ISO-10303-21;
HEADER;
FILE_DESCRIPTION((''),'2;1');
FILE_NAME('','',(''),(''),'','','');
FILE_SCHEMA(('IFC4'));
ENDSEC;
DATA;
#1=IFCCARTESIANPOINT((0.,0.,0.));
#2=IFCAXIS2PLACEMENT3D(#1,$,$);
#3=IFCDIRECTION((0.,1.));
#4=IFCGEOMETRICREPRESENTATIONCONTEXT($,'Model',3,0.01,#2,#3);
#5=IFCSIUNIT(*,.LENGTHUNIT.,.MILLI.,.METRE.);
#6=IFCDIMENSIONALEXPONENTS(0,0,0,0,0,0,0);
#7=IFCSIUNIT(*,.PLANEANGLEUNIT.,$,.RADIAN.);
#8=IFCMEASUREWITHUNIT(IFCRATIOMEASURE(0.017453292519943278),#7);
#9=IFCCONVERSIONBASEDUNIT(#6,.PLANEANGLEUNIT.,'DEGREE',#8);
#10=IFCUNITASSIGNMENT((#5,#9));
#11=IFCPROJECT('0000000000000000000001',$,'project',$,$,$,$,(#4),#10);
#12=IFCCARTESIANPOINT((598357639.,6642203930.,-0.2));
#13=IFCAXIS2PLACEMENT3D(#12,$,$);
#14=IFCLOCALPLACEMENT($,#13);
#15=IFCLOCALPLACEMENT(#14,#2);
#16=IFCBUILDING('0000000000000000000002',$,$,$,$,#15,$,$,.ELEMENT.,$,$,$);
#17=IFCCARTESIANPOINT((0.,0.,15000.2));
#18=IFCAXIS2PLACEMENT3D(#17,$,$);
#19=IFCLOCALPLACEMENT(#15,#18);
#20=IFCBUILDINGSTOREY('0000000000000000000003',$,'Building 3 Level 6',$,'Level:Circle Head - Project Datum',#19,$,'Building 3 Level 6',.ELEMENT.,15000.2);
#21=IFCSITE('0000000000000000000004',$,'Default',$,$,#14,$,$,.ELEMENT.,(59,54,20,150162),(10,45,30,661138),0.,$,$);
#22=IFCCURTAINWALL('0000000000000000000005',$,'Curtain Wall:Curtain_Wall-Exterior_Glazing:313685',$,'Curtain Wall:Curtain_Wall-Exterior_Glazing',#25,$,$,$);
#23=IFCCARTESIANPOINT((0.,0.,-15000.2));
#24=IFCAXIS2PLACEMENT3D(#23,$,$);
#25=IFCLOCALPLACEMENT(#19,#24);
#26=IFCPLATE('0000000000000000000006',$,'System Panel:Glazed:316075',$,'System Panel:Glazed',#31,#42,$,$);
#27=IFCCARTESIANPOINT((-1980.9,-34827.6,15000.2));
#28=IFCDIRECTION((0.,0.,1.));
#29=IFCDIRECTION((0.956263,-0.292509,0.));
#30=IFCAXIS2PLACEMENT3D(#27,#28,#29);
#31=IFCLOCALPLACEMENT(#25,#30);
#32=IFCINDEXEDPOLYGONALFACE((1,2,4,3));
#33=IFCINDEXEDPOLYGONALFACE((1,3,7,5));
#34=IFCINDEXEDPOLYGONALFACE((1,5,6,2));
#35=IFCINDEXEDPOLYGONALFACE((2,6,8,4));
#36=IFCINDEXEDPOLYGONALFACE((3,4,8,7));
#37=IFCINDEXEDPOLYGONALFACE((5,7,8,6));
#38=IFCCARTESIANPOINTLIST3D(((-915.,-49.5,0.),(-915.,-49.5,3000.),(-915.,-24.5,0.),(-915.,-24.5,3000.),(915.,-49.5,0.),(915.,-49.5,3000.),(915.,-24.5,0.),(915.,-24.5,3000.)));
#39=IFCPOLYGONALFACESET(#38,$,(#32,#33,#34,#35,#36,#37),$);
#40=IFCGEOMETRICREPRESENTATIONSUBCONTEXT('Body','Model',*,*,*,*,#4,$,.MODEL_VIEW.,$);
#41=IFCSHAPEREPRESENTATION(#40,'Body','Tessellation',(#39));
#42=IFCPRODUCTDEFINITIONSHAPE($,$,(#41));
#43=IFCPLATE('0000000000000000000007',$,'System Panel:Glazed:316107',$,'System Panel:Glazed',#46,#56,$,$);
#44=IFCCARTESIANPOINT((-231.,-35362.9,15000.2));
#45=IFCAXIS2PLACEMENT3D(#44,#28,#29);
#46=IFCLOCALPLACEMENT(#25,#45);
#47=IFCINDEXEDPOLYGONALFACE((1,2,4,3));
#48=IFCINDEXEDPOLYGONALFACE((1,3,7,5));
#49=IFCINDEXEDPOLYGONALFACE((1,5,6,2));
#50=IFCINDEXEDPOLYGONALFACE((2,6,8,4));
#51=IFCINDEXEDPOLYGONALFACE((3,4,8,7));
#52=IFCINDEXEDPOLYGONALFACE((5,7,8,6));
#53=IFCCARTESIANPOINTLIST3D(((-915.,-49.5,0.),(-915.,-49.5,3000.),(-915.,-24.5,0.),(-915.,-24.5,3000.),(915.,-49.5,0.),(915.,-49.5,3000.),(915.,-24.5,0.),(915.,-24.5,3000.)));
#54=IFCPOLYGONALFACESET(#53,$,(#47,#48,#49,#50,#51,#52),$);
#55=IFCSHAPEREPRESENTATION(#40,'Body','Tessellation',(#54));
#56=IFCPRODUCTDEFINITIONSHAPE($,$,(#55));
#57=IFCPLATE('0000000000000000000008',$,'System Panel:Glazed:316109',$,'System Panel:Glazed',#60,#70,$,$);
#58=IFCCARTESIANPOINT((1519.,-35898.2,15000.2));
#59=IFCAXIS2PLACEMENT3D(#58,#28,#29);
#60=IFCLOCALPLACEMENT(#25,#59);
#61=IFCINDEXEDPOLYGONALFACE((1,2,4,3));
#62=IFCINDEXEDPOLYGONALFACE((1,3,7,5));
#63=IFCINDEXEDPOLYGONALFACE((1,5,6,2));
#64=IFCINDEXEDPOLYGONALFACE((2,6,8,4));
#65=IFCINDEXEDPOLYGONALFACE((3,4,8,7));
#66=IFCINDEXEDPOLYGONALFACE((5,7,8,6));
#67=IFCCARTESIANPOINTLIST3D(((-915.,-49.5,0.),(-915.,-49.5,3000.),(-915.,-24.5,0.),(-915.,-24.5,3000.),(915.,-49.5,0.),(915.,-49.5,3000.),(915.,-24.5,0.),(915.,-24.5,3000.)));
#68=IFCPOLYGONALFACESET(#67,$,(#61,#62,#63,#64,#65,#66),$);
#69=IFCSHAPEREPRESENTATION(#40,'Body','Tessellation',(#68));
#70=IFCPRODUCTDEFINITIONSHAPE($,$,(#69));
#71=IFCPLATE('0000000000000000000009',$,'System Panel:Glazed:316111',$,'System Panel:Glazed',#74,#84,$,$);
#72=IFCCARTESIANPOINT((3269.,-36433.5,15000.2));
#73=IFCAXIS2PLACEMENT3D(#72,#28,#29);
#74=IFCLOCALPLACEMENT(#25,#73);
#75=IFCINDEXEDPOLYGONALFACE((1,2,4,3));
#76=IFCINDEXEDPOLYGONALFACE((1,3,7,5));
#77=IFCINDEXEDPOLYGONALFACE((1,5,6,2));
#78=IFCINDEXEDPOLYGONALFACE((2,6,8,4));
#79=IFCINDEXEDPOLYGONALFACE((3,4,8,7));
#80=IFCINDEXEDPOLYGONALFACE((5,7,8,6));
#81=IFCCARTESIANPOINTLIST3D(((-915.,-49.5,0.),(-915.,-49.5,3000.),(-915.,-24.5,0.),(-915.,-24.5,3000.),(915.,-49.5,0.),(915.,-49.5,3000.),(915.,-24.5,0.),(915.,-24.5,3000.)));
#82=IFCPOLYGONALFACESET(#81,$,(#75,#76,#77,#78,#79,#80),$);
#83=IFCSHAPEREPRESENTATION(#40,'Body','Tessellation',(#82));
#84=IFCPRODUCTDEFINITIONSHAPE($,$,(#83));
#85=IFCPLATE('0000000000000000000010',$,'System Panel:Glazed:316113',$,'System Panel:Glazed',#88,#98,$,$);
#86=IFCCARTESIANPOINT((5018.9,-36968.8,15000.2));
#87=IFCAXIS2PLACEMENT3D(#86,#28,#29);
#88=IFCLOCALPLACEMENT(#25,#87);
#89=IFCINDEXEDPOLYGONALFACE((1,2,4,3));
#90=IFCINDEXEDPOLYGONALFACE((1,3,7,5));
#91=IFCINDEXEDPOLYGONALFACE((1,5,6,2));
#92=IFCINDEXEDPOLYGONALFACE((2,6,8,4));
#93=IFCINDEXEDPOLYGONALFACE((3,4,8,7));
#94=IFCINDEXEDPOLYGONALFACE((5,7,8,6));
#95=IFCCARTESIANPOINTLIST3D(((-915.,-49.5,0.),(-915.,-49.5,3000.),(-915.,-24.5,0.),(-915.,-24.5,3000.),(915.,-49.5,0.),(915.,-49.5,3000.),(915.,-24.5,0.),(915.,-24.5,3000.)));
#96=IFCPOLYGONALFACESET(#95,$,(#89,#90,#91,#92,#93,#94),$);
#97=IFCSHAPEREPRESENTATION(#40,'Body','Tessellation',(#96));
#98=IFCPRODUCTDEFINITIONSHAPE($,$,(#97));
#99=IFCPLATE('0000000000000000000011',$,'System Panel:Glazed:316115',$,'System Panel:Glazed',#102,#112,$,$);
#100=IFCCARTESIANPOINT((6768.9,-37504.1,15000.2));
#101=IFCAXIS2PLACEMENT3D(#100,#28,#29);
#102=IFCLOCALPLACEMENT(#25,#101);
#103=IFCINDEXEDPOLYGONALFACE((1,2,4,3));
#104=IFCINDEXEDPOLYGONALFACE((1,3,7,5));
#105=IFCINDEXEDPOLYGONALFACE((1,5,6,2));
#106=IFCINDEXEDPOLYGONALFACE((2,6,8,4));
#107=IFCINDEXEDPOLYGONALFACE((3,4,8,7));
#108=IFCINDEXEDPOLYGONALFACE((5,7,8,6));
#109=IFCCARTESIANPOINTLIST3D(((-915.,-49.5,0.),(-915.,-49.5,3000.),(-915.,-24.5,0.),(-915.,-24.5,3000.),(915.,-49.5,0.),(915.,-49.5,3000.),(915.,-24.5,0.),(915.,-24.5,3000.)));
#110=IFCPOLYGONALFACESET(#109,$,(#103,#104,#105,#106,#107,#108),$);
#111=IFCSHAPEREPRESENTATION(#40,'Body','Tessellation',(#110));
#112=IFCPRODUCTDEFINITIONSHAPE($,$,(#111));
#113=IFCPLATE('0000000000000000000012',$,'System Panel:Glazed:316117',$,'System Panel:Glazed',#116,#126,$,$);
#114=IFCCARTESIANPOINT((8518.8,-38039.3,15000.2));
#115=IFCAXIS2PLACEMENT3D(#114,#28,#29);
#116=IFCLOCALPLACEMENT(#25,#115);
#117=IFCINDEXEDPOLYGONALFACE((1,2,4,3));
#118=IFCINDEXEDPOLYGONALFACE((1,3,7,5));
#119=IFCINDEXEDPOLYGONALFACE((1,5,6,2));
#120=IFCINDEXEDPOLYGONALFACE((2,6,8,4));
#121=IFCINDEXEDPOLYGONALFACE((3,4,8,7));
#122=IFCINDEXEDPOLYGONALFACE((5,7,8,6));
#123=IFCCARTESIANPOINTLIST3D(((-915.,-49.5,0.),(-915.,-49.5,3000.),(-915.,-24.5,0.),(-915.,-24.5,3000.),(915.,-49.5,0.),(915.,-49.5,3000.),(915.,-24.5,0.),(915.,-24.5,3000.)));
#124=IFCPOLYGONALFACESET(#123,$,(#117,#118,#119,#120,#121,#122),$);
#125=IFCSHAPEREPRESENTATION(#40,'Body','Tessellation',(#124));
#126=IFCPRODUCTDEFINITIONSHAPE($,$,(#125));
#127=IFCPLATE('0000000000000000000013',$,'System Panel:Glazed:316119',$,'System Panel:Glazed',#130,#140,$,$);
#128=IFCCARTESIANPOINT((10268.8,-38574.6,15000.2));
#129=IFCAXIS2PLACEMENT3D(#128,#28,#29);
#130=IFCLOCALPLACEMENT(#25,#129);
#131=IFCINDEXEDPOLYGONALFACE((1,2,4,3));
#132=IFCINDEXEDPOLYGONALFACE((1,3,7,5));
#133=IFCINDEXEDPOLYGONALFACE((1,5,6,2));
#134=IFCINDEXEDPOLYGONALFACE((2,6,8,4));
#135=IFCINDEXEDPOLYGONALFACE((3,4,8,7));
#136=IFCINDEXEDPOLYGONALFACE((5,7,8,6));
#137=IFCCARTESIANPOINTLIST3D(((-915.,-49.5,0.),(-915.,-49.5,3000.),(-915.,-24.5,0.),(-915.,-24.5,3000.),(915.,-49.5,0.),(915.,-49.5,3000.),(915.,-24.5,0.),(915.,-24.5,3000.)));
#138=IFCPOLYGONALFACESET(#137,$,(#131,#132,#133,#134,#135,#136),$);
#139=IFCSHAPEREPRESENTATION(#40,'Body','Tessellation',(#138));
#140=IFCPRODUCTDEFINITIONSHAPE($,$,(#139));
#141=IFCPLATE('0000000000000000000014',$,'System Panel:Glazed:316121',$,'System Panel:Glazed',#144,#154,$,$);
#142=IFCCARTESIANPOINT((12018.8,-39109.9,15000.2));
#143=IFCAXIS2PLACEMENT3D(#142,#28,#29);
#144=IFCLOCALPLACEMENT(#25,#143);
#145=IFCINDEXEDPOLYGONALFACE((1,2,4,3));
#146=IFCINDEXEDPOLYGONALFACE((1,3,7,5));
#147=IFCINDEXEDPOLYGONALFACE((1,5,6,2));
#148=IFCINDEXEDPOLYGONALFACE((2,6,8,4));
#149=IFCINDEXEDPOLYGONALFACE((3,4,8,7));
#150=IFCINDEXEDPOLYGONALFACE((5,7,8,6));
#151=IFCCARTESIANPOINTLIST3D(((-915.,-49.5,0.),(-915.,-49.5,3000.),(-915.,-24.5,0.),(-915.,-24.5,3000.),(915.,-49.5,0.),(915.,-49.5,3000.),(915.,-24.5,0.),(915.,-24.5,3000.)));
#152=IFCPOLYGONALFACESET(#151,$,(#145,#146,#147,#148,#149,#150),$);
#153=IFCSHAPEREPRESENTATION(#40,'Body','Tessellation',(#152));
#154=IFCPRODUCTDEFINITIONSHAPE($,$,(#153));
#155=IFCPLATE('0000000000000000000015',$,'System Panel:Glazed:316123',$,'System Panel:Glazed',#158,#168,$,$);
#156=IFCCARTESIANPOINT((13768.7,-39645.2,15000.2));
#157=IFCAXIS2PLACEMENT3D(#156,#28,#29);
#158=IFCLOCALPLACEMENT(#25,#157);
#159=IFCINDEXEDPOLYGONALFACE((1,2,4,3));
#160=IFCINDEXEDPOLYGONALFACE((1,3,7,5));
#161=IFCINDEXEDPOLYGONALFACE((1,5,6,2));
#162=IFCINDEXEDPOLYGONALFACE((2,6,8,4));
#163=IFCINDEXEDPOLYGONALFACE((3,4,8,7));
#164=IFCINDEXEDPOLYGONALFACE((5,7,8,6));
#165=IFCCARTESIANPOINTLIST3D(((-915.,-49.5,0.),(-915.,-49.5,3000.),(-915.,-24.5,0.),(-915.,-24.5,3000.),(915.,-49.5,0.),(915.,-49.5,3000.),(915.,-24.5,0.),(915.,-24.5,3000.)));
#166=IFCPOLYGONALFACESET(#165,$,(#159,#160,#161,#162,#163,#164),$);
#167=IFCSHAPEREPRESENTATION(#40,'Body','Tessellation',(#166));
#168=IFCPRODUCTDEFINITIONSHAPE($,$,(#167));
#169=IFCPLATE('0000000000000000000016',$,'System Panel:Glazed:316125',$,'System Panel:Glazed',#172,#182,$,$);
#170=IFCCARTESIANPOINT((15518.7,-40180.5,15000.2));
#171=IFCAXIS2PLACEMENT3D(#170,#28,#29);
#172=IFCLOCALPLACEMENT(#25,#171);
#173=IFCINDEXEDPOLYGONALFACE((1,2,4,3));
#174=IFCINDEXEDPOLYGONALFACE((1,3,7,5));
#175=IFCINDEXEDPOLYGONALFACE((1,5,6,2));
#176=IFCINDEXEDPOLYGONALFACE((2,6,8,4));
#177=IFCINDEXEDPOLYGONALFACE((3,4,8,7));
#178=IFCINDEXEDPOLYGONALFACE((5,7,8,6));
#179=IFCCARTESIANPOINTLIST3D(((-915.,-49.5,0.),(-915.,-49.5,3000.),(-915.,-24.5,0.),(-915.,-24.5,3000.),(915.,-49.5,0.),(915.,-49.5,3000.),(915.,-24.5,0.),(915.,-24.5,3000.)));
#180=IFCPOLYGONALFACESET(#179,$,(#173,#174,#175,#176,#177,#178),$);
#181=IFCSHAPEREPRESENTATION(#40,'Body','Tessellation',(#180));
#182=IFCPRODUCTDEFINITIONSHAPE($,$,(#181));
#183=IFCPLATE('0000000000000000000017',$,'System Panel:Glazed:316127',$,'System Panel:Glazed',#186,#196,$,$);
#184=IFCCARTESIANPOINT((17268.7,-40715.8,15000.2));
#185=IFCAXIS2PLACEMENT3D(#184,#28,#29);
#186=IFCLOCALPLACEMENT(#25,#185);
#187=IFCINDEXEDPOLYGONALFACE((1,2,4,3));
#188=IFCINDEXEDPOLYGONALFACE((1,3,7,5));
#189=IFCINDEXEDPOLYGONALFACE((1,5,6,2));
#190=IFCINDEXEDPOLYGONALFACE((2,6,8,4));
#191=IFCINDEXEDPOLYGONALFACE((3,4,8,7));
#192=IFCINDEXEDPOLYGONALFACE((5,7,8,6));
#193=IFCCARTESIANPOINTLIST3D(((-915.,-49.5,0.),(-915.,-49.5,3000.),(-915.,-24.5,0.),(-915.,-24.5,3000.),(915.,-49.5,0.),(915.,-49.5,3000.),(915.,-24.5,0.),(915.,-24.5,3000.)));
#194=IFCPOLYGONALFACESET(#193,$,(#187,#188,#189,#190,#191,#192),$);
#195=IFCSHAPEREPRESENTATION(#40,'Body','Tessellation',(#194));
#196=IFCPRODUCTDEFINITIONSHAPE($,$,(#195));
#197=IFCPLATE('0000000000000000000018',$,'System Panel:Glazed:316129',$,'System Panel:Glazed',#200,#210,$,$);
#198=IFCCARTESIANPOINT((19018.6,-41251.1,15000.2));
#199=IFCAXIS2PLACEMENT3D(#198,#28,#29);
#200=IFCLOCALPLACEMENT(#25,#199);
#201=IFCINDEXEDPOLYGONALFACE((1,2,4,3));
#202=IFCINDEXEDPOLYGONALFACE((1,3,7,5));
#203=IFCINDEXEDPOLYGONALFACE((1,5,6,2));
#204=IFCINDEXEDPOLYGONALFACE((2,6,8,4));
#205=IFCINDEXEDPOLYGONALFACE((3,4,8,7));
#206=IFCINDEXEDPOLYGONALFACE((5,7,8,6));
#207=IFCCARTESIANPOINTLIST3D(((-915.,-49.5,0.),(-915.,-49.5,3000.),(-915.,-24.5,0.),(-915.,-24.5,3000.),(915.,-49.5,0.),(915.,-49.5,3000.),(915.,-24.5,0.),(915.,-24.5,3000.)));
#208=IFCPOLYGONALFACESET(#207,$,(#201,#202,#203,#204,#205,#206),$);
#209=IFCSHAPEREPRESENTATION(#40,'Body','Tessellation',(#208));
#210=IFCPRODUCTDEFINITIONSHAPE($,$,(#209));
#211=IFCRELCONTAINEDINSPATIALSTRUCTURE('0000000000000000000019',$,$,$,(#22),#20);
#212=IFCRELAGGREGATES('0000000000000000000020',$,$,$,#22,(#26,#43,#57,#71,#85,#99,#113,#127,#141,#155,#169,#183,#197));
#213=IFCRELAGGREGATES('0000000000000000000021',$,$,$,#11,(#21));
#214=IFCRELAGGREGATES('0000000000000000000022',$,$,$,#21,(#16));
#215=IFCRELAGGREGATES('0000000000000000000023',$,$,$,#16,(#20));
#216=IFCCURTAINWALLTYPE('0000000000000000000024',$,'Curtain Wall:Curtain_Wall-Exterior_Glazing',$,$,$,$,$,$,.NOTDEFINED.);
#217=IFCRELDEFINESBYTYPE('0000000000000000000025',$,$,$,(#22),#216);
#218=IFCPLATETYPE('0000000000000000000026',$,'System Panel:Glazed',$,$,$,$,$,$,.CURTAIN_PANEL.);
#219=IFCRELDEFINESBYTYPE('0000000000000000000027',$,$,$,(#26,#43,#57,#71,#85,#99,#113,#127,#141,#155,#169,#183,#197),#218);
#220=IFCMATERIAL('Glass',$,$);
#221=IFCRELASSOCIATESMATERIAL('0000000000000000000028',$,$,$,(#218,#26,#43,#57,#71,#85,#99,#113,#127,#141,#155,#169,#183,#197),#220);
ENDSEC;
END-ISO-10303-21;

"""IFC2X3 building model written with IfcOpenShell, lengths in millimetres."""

from ifc_helpers import new_model, entity, si_unit, converted_unit, direction, frame, frame_2d, origin, place, context, subcontext, project, spatial, rectangle, extrude, source, transform, mapped, material, type_object, type_shapes, element, aggregate, save


model = new_model("IFC2X3")

# Units and contexts
model_context = context("Model", 3, precision=0.01, world=origin(), true_north=direction((0.0, 1.0)))
body_context = subcontext(model_context, "Body", "Model", "MODEL_VIEW")
ifc_project = project(units=[si_unit("LENGTHUNIT", "METRE", prefix="MILLI"), converted_unit("PLANEANGLEUNIT", "DEGREE", entity("IfcRatioMeasure", 0.017453292519943278), si_unit("PLANEANGLEUNIT", "RADIAN"), dimensions=[0, 0, 0, 0, 0, 0, 0])], contexts=[model_context])

# Site, building, storey
site_placement = place(None, frame((598357639.0, 6642203930.0, -0.2)))
site = spatial("IfcSite", under=ifc_project, at=site_placement, Name="Default", CompositionType="ELEMENT", RefLatitude=(59, 54, 20, 150162), RefLongitude=(10, 45, 30, 661138), RefElevation=0.0)
building_placement = place(site_placement, origin())
building = spatial("IfcBuilding", under=site, at=building_placement, CompositionType="ELEMENT")
storey_placement = place(building_placement, frame((0.0, 0.0, 15000.2)))
storey = spatial("IfcBuildingStorey", under=building, at=storey_placement, Name="Building 3 Level 6", ObjectType="Level:Circle Head - Project Datum", LongName="Building 3 Level 6", CompositionType="ELEMENT", Elevation=15000.2)

# Curtain wall, plates
curtain_wall_type = type_object("IfcCurtainWallType", Name="Curtain Wall:Curtain_Wall-Exterior_Glazing", PredefinedType="NOTDEFINED")
ifc_material_1 = material(Name="Glass")
plate_type_1 = type_object("IfcPlateType", Name="System Panel:Glazed", PredefinedType="CURTAIN_PANEL", material=ifc_material_1)
shared_shape_1 = source(origin(), body_context, "Body", "SweptSolid", [
    extrude(rectangle(XDim=25.0, YDim=1830.0, at=frame_2d((0.0, 0.0), x_axis=(1.0, 0.0))), frame((0.0, -37.0, 0.0), z_axis=(0.0, 0.0, 1.0), x_axis=(0.0, 1.0, 0.0)), (0.0, 0.0, 1.0), 3000.0),
])
type_shapes(plate_type_1, [shared_shape_1])
curtain_wall_1_placement = place(storey_placement, frame((0.0, 0.0, -15000.2)))
curtain_wall_1 = element("IfcCurtainWall", 1, at=curtain_wall_1_placement, inside=storey, type_object=curtain_wall_type, Name="Curtain Wall:Curtain_Wall-Exterior_Glazing:313685", ObjectType="Curtain Wall:Curtain_Wall-Exterior_Glazing")
plate_1_placement = place(curtain_wall_1_placement, frame((-1980.9, -34827.6, 15000.2), z_axis=(0.0, 0.0, 1.0), x_axis=(0.956263, -0.292509, 0.0)))
plate_1 = element("IfcPlate", 2, at=plate_1_placement, type_object=plate_type_1, material=ifc_material_1, Name="System Panel:Glazed:316075", ObjectType="System Panel:Glazed", context=body_context, shape_type="MappedRepresentation", body=[
    mapped(shared_shape_1, transform((0.0, 0.0, 0.0), scale=1.0)),
])
plate_2_placement = place(curtain_wall_1_placement, frame((-231.0, -35362.9, 15000.2), z_axis=(0.0, 0.0, 1.0), x_axis=(0.956263, -0.292509, 0.0)))
plate_2 = element("IfcPlate", 3, at=plate_2_placement, type_object=plate_type_1, material=ifc_material_1, Name="System Panel:Glazed:316107", ObjectType="System Panel:Glazed", context=body_context, shape_type="MappedRepresentation", body=[
    mapped(shared_shape_1, transform((0.0, 0.0, 0.0), scale=1.0)),
])
plate_3_placement = place(curtain_wall_1_placement, frame((1519.0, -35898.2, 15000.2), z_axis=(0.0, 0.0, 1.0), x_axis=(0.956263, -0.292509, 0.0)))
plate_3 = element("IfcPlate", 4, at=plate_3_placement, type_object=plate_type_1, material=ifc_material_1, Name="System Panel:Glazed:316109", ObjectType="System Panel:Glazed", context=body_context, shape_type="MappedRepresentation", body=[
    mapped(shared_shape_1, transform((0.0, 0.0, 0.0), scale=1.0)),
])
plate_4_placement = place(curtain_wall_1_placement, frame((3269.0, -36433.5, 15000.2), z_axis=(0.0, 0.0, 1.0), x_axis=(0.956263, -0.292509, 0.0)))
plate_4 = element("IfcPlate", 5, at=plate_4_placement, type_object=plate_type_1, material=ifc_material_1, Name="System Panel:Glazed:316111", ObjectType="System Panel:Glazed", context=body_context, shape_type="MappedRepresentation", body=[
    mapped(shared_shape_1, transform((0.0, 0.0, 0.0), scale=1.0)),
])
plate_5_placement = place(curtain_wall_1_placement, frame((5018.9, -36968.8, 15000.2), z_axis=(0.0, 0.0, 1.0), x_axis=(0.956263, -0.292509, 0.0)))
plate_5 = element("IfcPlate", 6, at=plate_5_placement, type_object=plate_type_1, material=ifc_material_1, Name="System Panel:Glazed:316113", ObjectType="System Panel:Glazed", context=body_context, shape_type="MappedRepresentation", body=[
    mapped(shared_shape_1, transform((0.0, 0.0, 0.0), scale=1.0)),
])
plate_6_placement = place(curtain_wall_1_placement, frame((6768.9, -37504.1, 15000.2), z_axis=(0.0, 0.0, 1.0), x_axis=(0.956263, -0.292509, 0.0)))
plate_6 = element("IfcPlate", 7, at=plate_6_placement, type_object=plate_type_1, material=ifc_material_1, Name="System Panel:Glazed:316115", ObjectType="System Panel:Glazed", context=body_context, shape_type="MappedRepresentation", body=[
    mapped(shared_shape_1, transform((0.0, 0.0, 0.0), scale=1.0)),
])
plate_7_placement = place(curtain_wall_1_placement, frame((8518.8, -38039.3, 15000.2), z_axis=(0.0, 0.0, 1.0), x_axis=(0.956263, -0.292509, 0.0)))
plate_7 = element("IfcPlate", 8, at=plate_7_placement, type_object=plate_type_1, material=ifc_material_1, Name="System Panel:Glazed:316117", ObjectType="System Panel:Glazed", context=body_context, shape_type="MappedRepresentation", body=[
    mapped(shared_shape_1, transform((0.0, 0.0, 0.0), scale=1.0)),
])
plate_8_placement = place(curtain_wall_1_placement, frame((10268.8, -38574.6, 15000.2), z_axis=(0.0, 0.0, 1.0), x_axis=(0.956263, -0.292509, 0.0)))
plate_8 = element("IfcPlate", 9, at=plate_8_placement, type_object=plate_type_1, material=ifc_material_1, Name="System Panel:Glazed:316119", ObjectType="System Panel:Glazed", context=body_context, shape_type="MappedRepresentation", body=[
    mapped(shared_shape_1, transform((0.0, 0.0, 0.0), scale=1.0)),
])
plate_9_placement = place(curtain_wall_1_placement, frame((12018.8, -39109.9, 15000.2), z_axis=(0.0, 0.0, 1.0), x_axis=(0.956263, -0.292509, 0.0)))
plate_9 = element("IfcPlate", 10, at=plate_9_placement, type_object=plate_type_1, material=ifc_material_1, Name="System Panel:Glazed:316121", ObjectType="System Panel:Glazed", context=body_context, shape_type="MappedRepresentation", body=[
    mapped(shared_shape_1, transform((0.0, 0.0, 0.0), scale=1.0)),
])
plate_10_placement = place(curtain_wall_1_placement, frame((13768.7, -39645.2, 15000.2), z_axis=(0.0, 0.0, 1.0), x_axis=(0.956263, -0.292509, 0.0)))
plate_10 = element("IfcPlate", 11, at=plate_10_placement, type_object=plate_type_1, material=ifc_material_1, Name="System Panel:Glazed:316123", ObjectType="System Panel:Glazed", context=body_context, shape_type="MappedRepresentation", body=[
    mapped(shared_shape_1, transform((0.0, 0.0, 0.0), scale=1.0)),
])
plate_11_placement = place(curtain_wall_1_placement, frame((15518.7, -40180.5, 15000.2), z_axis=(0.0, 0.0, 1.0), x_axis=(0.956263, -0.292509, 0.0)))
plate_11 = element("IfcPlate", 12, at=plate_11_placement, type_object=plate_type_1, material=ifc_material_1, Name="System Panel:Glazed:316125", ObjectType="System Panel:Glazed", context=body_context, shape_type="MappedRepresentation", body=[
    mapped(shared_shape_1, transform((0.0, 0.0, 0.0), scale=1.0)),
])
plate_12_placement = place(curtain_wall_1_placement, frame((17268.7, -40715.8, 15000.2), z_axis=(0.0, 0.0, 1.0), x_axis=(0.956263, -0.292509, 0.0)))
plate_12 = element("IfcPlate", 13, at=plate_12_placement, type_object=plate_type_1, material=ifc_material_1, Name="System Panel:Glazed:316127", ObjectType="System Panel:Glazed", context=body_context, shape_type="MappedRepresentation", body=[
    mapped(shared_shape_1, transform((0.0, 0.0, 0.0), scale=1.0)),
])
plate_13_placement = place(curtain_wall_1_placement, frame((19018.6, -41251.1, 15000.2), z_axis=(0.0, 0.0, 1.0), x_axis=(0.956263, -0.292509, 0.0)))
plate_13 = element("IfcPlate", 14, at=plate_13_placement, type_object=plate_type_1, material=ifc_material_1, Name="System Panel:Glazed:316129", ObjectType="System Panel:Glazed", context=body_context, shape_type="MappedRepresentation", body=[
    mapped(shared_shape_1, transform((0.0, 0.0, 0.0), scale=1.0)),
])

aggregate(curtain_wall_1, [plate_1, plate_2, plate_3, plate_4, plate_5, plate_6, plate_7, plate_8, plate_9, plate_10, plate_11, plate_12, plate_13])

save(model, "model.ifc")
